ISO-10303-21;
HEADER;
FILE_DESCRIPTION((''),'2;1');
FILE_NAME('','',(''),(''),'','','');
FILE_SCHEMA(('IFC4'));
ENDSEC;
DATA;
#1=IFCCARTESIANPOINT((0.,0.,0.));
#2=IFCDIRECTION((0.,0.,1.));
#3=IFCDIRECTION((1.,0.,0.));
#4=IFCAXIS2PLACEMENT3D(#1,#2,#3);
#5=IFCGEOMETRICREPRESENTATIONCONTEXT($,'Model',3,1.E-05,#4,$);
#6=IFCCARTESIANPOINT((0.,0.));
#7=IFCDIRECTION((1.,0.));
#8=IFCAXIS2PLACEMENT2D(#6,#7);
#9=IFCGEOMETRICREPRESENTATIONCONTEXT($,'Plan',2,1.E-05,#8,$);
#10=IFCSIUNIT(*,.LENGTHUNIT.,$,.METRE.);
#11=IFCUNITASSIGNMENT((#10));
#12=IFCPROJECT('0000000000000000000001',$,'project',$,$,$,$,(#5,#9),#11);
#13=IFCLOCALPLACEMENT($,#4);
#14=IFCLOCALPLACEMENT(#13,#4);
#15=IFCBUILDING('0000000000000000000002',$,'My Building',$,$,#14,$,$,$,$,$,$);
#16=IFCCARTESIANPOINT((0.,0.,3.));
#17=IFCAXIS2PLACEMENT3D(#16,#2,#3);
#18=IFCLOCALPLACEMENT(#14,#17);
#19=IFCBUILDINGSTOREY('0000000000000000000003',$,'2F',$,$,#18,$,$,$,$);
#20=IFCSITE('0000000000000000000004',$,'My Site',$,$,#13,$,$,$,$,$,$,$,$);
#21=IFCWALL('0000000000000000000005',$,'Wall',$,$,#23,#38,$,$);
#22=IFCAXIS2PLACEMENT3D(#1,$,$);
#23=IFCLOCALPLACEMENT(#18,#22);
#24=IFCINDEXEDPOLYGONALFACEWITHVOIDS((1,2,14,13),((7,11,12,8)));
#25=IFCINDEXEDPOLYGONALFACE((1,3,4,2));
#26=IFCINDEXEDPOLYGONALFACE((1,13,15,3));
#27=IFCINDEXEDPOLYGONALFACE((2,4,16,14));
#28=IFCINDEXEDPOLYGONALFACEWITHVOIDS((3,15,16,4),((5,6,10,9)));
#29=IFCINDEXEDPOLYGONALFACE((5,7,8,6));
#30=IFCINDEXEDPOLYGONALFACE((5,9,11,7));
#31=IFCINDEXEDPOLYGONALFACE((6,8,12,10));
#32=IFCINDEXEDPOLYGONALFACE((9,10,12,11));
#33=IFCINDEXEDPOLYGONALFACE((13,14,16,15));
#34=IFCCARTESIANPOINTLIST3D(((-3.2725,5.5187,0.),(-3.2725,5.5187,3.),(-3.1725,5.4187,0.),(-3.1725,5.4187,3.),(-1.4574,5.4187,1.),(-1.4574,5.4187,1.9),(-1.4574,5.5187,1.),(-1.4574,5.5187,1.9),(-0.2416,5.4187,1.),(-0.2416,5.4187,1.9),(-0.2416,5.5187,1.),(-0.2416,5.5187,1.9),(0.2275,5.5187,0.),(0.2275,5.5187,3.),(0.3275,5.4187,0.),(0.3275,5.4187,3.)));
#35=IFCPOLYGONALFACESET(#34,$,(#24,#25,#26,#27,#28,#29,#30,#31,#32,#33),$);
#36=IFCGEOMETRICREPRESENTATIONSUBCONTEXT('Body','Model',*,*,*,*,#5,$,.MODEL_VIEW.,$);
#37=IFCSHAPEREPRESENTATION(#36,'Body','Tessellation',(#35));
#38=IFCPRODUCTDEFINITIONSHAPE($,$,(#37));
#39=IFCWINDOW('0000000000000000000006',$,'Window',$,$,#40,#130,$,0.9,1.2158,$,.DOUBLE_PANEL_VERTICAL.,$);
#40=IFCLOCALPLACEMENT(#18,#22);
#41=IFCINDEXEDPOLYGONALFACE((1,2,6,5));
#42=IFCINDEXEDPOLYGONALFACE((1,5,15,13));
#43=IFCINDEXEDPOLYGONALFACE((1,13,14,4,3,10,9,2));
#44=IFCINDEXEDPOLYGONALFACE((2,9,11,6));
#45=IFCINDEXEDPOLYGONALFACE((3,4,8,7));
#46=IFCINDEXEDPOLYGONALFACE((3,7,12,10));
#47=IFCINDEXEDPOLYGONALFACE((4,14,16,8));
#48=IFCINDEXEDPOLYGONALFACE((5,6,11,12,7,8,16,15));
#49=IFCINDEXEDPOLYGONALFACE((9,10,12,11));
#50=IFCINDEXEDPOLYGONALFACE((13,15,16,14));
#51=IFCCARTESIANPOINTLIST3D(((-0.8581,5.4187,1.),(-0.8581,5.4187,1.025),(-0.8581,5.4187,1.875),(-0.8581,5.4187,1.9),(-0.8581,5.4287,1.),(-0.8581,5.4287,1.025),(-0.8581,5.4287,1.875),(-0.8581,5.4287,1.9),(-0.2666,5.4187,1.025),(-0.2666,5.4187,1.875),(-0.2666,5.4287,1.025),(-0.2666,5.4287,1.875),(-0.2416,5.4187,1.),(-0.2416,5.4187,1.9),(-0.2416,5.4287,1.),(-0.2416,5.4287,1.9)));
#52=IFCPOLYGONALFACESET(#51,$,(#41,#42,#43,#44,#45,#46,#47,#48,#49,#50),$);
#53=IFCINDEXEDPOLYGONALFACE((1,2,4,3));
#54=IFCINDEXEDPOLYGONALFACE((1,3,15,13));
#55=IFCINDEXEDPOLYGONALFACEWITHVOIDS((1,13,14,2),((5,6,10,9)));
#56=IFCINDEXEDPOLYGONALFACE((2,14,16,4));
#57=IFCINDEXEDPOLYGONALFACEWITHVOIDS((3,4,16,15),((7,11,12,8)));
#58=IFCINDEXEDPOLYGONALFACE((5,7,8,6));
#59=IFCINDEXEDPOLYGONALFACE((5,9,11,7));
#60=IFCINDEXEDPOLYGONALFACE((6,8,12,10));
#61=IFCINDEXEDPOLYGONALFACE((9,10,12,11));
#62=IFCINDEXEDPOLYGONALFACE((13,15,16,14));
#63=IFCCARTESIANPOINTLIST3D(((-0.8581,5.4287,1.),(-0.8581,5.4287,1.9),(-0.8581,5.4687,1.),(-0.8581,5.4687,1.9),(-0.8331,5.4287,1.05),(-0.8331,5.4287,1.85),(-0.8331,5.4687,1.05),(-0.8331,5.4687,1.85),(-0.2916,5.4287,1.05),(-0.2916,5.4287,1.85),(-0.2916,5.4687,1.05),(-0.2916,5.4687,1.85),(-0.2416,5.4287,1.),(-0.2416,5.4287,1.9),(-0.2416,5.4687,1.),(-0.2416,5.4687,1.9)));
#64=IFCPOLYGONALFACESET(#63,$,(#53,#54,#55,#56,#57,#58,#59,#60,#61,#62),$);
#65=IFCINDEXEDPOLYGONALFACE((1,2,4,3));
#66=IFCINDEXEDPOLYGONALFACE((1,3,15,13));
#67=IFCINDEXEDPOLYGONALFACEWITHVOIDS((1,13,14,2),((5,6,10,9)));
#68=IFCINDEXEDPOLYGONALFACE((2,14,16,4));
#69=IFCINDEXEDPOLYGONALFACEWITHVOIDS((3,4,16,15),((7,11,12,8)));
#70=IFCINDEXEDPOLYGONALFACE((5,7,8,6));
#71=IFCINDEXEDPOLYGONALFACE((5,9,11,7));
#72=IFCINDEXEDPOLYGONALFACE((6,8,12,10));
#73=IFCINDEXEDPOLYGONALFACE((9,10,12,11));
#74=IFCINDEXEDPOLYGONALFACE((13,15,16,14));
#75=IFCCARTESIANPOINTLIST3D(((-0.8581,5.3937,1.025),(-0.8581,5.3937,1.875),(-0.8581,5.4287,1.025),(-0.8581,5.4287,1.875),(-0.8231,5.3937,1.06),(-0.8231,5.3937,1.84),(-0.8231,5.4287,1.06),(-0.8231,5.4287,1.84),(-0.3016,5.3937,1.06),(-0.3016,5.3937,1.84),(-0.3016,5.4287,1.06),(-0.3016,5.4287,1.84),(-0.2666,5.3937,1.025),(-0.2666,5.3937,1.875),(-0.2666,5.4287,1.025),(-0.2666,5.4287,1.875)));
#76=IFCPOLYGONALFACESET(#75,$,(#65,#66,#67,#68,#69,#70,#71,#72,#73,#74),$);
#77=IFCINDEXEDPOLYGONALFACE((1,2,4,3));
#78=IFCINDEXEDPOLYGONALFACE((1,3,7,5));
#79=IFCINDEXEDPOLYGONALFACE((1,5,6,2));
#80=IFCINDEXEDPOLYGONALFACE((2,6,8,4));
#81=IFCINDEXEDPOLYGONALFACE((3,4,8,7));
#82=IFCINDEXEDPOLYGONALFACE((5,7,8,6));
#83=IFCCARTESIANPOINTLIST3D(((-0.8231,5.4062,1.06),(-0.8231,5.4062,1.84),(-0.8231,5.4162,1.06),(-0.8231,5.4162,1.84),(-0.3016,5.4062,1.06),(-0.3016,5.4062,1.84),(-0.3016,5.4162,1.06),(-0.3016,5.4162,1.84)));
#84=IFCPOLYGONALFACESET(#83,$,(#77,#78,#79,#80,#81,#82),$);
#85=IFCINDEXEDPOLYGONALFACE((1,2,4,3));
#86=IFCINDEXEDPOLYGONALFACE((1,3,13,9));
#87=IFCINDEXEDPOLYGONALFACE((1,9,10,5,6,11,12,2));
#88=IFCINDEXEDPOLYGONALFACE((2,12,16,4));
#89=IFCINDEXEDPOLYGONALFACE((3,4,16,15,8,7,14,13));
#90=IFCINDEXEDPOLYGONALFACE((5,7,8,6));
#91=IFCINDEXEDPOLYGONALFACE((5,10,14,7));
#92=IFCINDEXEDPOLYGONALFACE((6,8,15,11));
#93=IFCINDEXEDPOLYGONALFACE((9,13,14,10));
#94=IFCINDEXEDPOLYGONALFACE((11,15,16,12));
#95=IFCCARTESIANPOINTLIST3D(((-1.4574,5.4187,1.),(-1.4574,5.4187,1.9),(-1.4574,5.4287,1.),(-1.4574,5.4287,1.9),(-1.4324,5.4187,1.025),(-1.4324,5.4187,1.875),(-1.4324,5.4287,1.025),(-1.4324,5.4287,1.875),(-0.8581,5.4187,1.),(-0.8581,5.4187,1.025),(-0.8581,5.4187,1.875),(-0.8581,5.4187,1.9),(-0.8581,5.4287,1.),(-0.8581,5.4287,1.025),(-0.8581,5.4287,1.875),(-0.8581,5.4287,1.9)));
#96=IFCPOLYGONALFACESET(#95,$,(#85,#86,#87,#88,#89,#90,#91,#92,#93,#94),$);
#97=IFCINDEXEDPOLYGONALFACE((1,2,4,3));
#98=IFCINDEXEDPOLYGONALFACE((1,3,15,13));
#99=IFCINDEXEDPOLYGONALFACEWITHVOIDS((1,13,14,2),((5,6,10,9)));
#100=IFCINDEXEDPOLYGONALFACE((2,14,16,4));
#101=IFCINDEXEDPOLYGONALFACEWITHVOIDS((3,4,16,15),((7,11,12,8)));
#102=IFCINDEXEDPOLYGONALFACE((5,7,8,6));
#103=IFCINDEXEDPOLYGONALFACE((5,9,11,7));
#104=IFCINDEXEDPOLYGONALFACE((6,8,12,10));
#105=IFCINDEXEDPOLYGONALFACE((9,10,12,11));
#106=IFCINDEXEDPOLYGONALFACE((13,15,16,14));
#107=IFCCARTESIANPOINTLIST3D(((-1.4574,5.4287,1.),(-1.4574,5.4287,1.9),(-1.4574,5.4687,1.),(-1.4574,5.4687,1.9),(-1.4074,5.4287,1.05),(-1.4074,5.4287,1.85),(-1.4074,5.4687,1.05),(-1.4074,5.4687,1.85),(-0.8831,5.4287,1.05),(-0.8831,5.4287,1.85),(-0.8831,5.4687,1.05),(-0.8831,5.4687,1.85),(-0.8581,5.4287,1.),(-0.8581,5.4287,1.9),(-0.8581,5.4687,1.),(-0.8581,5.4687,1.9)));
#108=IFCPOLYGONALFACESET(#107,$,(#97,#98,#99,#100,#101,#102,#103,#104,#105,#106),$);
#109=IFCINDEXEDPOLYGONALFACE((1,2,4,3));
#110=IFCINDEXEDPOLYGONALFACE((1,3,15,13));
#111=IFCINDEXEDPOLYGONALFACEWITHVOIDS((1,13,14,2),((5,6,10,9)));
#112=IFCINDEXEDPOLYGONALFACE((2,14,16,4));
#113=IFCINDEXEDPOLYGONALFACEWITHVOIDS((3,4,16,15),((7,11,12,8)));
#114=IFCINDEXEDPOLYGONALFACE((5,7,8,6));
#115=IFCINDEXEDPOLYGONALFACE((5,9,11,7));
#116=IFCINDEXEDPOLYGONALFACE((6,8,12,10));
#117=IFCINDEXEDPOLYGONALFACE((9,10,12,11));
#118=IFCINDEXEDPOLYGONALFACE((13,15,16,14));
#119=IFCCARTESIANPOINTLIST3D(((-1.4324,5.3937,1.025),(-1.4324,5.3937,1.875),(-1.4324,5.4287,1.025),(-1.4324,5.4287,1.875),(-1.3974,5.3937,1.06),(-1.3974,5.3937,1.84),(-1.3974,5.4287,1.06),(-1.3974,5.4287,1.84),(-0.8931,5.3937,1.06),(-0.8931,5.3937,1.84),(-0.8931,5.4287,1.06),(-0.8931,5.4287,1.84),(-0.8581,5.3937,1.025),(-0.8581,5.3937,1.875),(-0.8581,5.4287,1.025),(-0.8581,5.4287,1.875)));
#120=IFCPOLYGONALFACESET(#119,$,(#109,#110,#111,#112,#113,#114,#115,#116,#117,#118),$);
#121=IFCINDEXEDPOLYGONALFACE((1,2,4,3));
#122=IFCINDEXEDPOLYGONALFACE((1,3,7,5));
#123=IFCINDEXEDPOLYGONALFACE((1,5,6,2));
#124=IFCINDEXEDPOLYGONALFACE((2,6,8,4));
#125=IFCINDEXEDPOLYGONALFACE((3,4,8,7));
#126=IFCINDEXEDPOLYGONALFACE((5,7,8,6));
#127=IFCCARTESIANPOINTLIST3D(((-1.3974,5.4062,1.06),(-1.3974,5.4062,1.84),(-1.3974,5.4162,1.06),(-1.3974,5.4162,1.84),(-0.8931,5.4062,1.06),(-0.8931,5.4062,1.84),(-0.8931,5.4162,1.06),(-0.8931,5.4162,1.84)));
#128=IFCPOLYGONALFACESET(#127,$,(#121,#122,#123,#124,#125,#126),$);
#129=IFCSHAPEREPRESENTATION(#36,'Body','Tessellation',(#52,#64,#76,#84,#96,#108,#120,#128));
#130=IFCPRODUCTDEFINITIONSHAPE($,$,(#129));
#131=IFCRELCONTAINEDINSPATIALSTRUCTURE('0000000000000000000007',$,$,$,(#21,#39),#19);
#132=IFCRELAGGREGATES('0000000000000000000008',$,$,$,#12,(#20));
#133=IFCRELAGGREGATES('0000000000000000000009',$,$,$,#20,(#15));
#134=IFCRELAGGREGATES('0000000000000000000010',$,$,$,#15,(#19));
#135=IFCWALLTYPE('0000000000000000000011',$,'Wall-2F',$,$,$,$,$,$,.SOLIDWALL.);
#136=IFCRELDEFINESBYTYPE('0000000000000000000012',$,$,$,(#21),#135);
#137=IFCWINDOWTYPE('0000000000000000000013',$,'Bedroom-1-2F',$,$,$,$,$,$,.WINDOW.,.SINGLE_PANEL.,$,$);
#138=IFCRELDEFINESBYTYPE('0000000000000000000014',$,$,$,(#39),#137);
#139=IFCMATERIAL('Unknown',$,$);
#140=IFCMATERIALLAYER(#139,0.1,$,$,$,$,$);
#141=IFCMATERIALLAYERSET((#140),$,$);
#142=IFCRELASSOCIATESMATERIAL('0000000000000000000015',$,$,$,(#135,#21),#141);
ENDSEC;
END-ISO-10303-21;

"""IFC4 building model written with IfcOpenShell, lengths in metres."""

from ifc_helpers import new_model, entity, si_unit, frame, origin_with_axes, origin_2d_with_axis, place, context, subcontext, project, spatial, line, indexed_curve, outline, extrude, shape, source, transform, mapped, material, layer, layer_set, layer_usage, type_object, type_shapes, element, fill, save


model = new_model("IFC4")

# Units and contexts
model_context = context("Model", 3, precision=1e-05, world=origin_with_axes())
plan_context = context("Plan", 2, precision=1e-05, world=origin_2d_with_axis())
body_context_1 = subcontext(model_context, "Body", "Model", "MODEL_VIEW")
body_context_2 = subcontext(plan_context, "Body", "Plan", "PLAN_VIEW")
ifc_project = project(units=[si_unit("LENGTHUNIT", "METRE")], contexts=[model_context, plan_context])

# Site, building, storey
site_placement = place(None, origin_with_axes())
site = spatial("IfcSite", under=ifc_project, at=site_placement, Name="My Site")
building_placement = place(site_placement, origin_with_axes())
building = spatial("IfcBuilding", under=site, at=building_placement, Name="My Building")
storey_placement = place(building_placement, frame((0.0, 0.0, 3.0), z_axis=(0.0, 0.0, 1.0), x_axis=(1.0, 0.0, 0.0)))
storey = spatial("IfcBuildingStorey", under=building, at=storey_placement, Name="2F")

# Shared definitions
ifc_material = material(Name="Unknown")

# Shared definitions
ifc_layer_1 = layer(ifc_material, 0.1)
ifc_layer_set_1 = layer_set([ifc_layer_1])
wall_type = type_object("IfcWallType", Name="Wall-2F", PredefinedType="SOLIDWALL", material=ifc_layer_set_1)

# Wall, opening, window
ifc_layer_usage_1 = layer_usage(ifc_layer_set_1, "AXIS2", "POSITIVE", 0.0)
wall_1_placement = place(storey_placement, frame((0.2275, 5.5187, 0.0), z_axis=(0.0, 0.0, 1.0), x_axis=(-1.0, 0.0, 0.0)))
wall_1 = element("IfcWall", 1, at=wall_1_placement, inside=storey, type_object=wall_type, material=ifc_layer_usage_1, Name="Wall", context=body_context_1, shape_type="SweptSolid", body=[
    extrude(outline(indexed_curve([(0.0, 0.0), (-0.1, 0.1), (3.4, 0.1), (3.5, 0.0)], segments=[line(1, 2, 3, 4, 1)])), origin_with_axes(), (0.0, 0.0, 1.0), 3.0),
])
shared_shape_1 = source(origin_with_axes(), body_context_1, "Body", "SweptSolid", [
    extrude(outline(indexed_curve([(0.0, 0.0), (1.2158, 0.0), (1.2158, 0.9), (0.0, 0.9)], segments=[line(1, 2, 3, 4, 1)])), frame((0.0, -0.6, 0.0), z_axis=(0.0, -1.0, 0.0), x_axis=(1.0, 0.0, 0.0)), (0.0, 0.0, -1.0), 1.2),
])
opening_1_placement = place(wall_1_placement, frame((0.4691, 0.0, 1.0), z_axis=(0.0, 0.0, 1.0), x_axis=(1.0, 0.0, 0.0)))
opening_1 = element("IfcOpeningElement", 2, at=opening_1_placement, cuts=wall_1, PredefinedType="OPENING", context=body_context_1, shape_type="MappedRepresentation", body=[
    mapped(shared_shape_1, transform((0.0, 0.0, 0.0), x_axis=(1.0, 0.0, 0.0), y_axis=(0.0, 1.0, 0.0), z_axis=(0.0, 0.0, 1.0), scale=1.0)),
])
window_type_1 = type_object("IfcWindowType", Name="Bedroom-1-2F", PartitioningType="SINGLE_PANEL", PredefinedType="WINDOW")
shared_shape_2 = source(origin_with_axes(), body_context_1, "Body", "SweptSolid", [
    extrude(outline(indexed_curve([(0.6164, 0.0), (0.0, 0.0), (0.0, 0.9), (0.6164, 0.9), (0.6164, 0.875), (0.025, 0.875), (0.025, 0.025), (0.6164, 0.025)], segments=[line(1, 2, 3, 4, 5, 6, 7, 8, 1)])), frame((0.0, 0.09, 0.0), z_axis=(0.0, -1.0, 0.0), x_axis=(1.0, 0.0, 0.0)), (0.0, 0.0, -1.0), 0.01),
    extrude(outline(indexed_curve([(0.0, 0.0), (0.6164, 0.0), (0.6164, 0.9), (0.0, 0.9)], segments=[line(1, 2, 3, 4, 1)]), holes=[indexed_curve([(0.05, 0.05), (0.5914, 0.05), (0.5914, 0.85), (0.05, 0.85)], segments=[line(1, 2, 3, 4, 1)])]), frame((0.0, 0.05, 0.0), z_axis=(0.0, -1.0, 0.0), x_axis=(1.0, 0.0, 0.0)), (0.0, 0.0, -1.0), 0.04),
    extrude(outline(indexed_curve([(0.0, 0.0), (0.5914, 0.0), (0.5914, 0.85), (0.0, 0.85)], segments=[line(1, 2, 3, 4, 1)]), holes=[indexed_curve([(0.035, 0.035), (0.5564, 0.035), (0.5564, 0.815), (0.035, 0.815)], segments=[line(1, 2, 3, 4, 1)])]), frame((0.025, 0.09, 0.025), z_axis=(0.0, -1.0, 0.0), x_axis=(1.0, 0.0, 0.0)), (0.0, 0.0, -1.0), 0.035),
    extrude(outline(indexed_curve([(0.035, 0.035), (0.5564, 0.035), (0.5564, 0.815), (0.035, 0.815)], segments=[line(1, 2, 3, 4, 1)])), frame((0.025, 0.1025, 0.025), z_axis=(0.0, -1.0, 0.0), x_axis=(1.0, 0.0, 0.0)), (0.0, 0.0, -1.0), 0.01),
    extrude(outline(indexed_curve([(0.0, 0.9), (0.5993, 0.9), (0.5993, 0.0), (0.0, 0.0), (0.0, 0.025), (0.5743, 0.025), (0.5743, 0.875), (0.0, 0.875)], segments=[line(1, 2, 3, 4, 5, 6, 7, 8, 1)])), frame((0.6164, 0.09, 0.0), z_axis=(0.0, -1.0, 0.0), x_axis=(1.0, 0.0, 0.0)), (0.0, 0.0, -1.0), 0.01),
    extrude(outline(indexed_curve([(0.0, 0.0), (0.5993, 0.0), (0.5993, 0.9), (0.0, 0.9)], segments=[line(1, 2, 3, 4, 1)]), holes=[indexed_curve([(0.025, 0.05), (0.5493, 0.05), (0.5493, 0.85), (0.025, 0.85)], segments=[line(1, 2, 3, 4, 1)])]), frame((0.6164, 0.05, 0.0), z_axis=(0.0, -1.0, 0.0), x_axis=(1.0, 0.0, 0.0)), (0.0, 0.0, -1.0), 0.04),
    extrude(outline(indexed_curve([(0.0, 0.0), (0.5743, 0.0), (0.5743, 0.85), (0.0, 0.85)], segments=[line(1, 2, 3, 4, 1)]), holes=[indexed_curve([(0.035, 0.035), (0.5393, 0.035), (0.5393, 0.815), (0.035, 0.815)], segments=[line(1, 2, 3, 4, 1)])]), frame((0.6164, 0.09, 0.025), z_axis=(0.0, -1.0, 0.0), x_axis=(1.0, 0.0, 0.0)), (0.0, 0.0, -1.0), 0.035),
    extrude(outline(indexed_curve([(0.035, 0.035), (0.5393, 0.035), (0.5393, 0.815), (0.035, 0.815)], segments=[line(1, 2, 3, 4, 1)])), frame((0.6164, 0.1025, 0.025), z_axis=(0.0, -1.0, 0.0), x_axis=(1.0, 0.0, 0.0)), (0.0, 0.0, -1.0), 0.01),
])
shared_shape_3 = source(origin_with_axes(), body_context_2, "Body", "Curve2D", [
    entity("IfcIndexedPolyCurve", entity("IfcCartesianPointList2D", [[0.05, 0.05], [0.5914, 0.05]])),
    entity("IfcIndexedPolyCurve", entity("IfcCartesianPointList2D", [[0.0, 0.1], [0.025, 0.1], [0.025, 0.09], [0.05, 0.09], [0.05, 0.05], [0.0, 0.05]]), [entity("IfcLineIndex", [1, 2, 3, 4, 5, 6, 1])]),
    entity("IfcIndexedPolyCurve", entity("IfcCartesianPointList2D", [[0.6164, 0.1], [0.6164, 0.1], [0.6164, 0.09], [0.5914, 0.09], [0.5914, 0.05], [0.6164, 0.05]])),
    entity("IfcIndexedPolyCurve", entity("IfcCartesianPointList2D", [[0.025, 0.09], [0.06, 0.09], [0.06, 0.125], [0.025, 0.125]]), [entity("IfcLineIndex", [1, 2, 3, 4, 1])]),
    entity("IfcIndexedPolyCurve", entity("IfcCartesianPointList2D", [[0.6164, 0.09], [0.5814, 0.09], [0.5814, 0.125], [0.6164, 0.125]]), [entity("IfcLineIndex", [1, 2, 3, 4, 1])]),
    entity("IfcIndexedPolyCurve", entity("IfcCartesianPointList2D", [[0.06, 0.09], [0.5814, 0.09]])),
    entity("IfcIndexedPolyCurve", entity("IfcCartesianPointList2D", [[0.06, 0.125], [0.5814, 0.125]])),
    entity("IfcIndexedPolyCurve", entity("IfcCartesianPointList2D", [[0.06, 0.1075], [0.5814, 0.1075]])),
    entity("IfcIndexedPolyCurve", entity("IfcCartesianPointList2D", [[0.6414, 0.05], [1.1658, 0.05]])),
    entity("IfcIndexedPolyCurve", entity("IfcCartesianPointList2D", [[0.6164, 0.1], [0.6164, 0.1], [0.6164, 0.09], [0.6414, 0.09], [0.6414, 0.05], [0.6164, 0.05]])),
    entity("IfcIndexedPolyCurve", entity("IfcCartesianPointList2D", [[1.2158, 0.1], [1.1908, 0.1], [1.1908, 0.09], [1.1658, 0.09], [1.1658, 0.05], [1.2158, 0.05]]), [entity("IfcLineIndex", [1, 2, 3, 4, 5, 6, 1])]),
    entity("IfcIndexedPolyCurve", entity("IfcCartesianPointList2D", [[0.6164, 0.09], [0.6514, 0.09], [0.6514, 0.125], [0.6164, 0.125]]), [entity("IfcLineIndex", [1, 2, 3, 4, 1])]),
    entity("IfcIndexedPolyCurve", entity("IfcCartesianPointList2D", [[1.1908, 0.09], [1.1558, 0.09], [1.1558, 0.125], [1.1908, 0.125]]), [entity("IfcLineIndex", [1, 2, 3, 4, 1])]),
    entity("IfcIndexedPolyCurve", entity("IfcCartesianPointList2D", [[0.6514, 0.09], [1.1558, 0.09]])),
    entity("IfcIndexedPolyCurve", entity("IfcCartesianPointList2D", [[0.6514, 0.125], [1.1558, 0.125]])),
    entity("IfcIndexedPolyCurve", entity("IfcCartesianPointList2D", [[0.6514, 0.1075], [1.1558, 0.1075]])),
])
type_shapes(window_type_1, [shared_shape_2, shared_shape_3])
window_1_placement = place(opening_1_placement, frame((0.0, 0.0, 0.0), z_axis=(0.0, 0.0, 1.0), x_axis=(1.0, 0.0, 0.0)))
window_1 = element("IfcWindow", 3, at=window_1_placement, inside=storey, type_object=window_type_1, Name="Window", OverallHeight=0.9, OverallWidth=1.2158, PartitioningType="DOUBLE_PANEL_VERTICAL", shapes=[
    shape(body_context_1, "Body", "MappedRepresentation", [mapped(shared_shape_2, transform((0.0, 0.0, 0.0), x_axis=(1.0, 0.0, 0.0), y_axis=(0.0, 1.0, 0.0), z_axis=(0.0, 0.0, 1.0), scale=1.0))]),
    shape(body_context_2, "Body", "MappedRepresentation", [mapped(shared_shape_3, transform((0.0, 0.0, 0.0), x_axis=(1.0, 0.0, 0.0), y_axis=(0.0, 1.0, 0.0), z_axis=(0.0, 0.0, 1.0), scale=1.0))]),
])
fill(opening_1, window_1)

save(model, "model.ifc")
